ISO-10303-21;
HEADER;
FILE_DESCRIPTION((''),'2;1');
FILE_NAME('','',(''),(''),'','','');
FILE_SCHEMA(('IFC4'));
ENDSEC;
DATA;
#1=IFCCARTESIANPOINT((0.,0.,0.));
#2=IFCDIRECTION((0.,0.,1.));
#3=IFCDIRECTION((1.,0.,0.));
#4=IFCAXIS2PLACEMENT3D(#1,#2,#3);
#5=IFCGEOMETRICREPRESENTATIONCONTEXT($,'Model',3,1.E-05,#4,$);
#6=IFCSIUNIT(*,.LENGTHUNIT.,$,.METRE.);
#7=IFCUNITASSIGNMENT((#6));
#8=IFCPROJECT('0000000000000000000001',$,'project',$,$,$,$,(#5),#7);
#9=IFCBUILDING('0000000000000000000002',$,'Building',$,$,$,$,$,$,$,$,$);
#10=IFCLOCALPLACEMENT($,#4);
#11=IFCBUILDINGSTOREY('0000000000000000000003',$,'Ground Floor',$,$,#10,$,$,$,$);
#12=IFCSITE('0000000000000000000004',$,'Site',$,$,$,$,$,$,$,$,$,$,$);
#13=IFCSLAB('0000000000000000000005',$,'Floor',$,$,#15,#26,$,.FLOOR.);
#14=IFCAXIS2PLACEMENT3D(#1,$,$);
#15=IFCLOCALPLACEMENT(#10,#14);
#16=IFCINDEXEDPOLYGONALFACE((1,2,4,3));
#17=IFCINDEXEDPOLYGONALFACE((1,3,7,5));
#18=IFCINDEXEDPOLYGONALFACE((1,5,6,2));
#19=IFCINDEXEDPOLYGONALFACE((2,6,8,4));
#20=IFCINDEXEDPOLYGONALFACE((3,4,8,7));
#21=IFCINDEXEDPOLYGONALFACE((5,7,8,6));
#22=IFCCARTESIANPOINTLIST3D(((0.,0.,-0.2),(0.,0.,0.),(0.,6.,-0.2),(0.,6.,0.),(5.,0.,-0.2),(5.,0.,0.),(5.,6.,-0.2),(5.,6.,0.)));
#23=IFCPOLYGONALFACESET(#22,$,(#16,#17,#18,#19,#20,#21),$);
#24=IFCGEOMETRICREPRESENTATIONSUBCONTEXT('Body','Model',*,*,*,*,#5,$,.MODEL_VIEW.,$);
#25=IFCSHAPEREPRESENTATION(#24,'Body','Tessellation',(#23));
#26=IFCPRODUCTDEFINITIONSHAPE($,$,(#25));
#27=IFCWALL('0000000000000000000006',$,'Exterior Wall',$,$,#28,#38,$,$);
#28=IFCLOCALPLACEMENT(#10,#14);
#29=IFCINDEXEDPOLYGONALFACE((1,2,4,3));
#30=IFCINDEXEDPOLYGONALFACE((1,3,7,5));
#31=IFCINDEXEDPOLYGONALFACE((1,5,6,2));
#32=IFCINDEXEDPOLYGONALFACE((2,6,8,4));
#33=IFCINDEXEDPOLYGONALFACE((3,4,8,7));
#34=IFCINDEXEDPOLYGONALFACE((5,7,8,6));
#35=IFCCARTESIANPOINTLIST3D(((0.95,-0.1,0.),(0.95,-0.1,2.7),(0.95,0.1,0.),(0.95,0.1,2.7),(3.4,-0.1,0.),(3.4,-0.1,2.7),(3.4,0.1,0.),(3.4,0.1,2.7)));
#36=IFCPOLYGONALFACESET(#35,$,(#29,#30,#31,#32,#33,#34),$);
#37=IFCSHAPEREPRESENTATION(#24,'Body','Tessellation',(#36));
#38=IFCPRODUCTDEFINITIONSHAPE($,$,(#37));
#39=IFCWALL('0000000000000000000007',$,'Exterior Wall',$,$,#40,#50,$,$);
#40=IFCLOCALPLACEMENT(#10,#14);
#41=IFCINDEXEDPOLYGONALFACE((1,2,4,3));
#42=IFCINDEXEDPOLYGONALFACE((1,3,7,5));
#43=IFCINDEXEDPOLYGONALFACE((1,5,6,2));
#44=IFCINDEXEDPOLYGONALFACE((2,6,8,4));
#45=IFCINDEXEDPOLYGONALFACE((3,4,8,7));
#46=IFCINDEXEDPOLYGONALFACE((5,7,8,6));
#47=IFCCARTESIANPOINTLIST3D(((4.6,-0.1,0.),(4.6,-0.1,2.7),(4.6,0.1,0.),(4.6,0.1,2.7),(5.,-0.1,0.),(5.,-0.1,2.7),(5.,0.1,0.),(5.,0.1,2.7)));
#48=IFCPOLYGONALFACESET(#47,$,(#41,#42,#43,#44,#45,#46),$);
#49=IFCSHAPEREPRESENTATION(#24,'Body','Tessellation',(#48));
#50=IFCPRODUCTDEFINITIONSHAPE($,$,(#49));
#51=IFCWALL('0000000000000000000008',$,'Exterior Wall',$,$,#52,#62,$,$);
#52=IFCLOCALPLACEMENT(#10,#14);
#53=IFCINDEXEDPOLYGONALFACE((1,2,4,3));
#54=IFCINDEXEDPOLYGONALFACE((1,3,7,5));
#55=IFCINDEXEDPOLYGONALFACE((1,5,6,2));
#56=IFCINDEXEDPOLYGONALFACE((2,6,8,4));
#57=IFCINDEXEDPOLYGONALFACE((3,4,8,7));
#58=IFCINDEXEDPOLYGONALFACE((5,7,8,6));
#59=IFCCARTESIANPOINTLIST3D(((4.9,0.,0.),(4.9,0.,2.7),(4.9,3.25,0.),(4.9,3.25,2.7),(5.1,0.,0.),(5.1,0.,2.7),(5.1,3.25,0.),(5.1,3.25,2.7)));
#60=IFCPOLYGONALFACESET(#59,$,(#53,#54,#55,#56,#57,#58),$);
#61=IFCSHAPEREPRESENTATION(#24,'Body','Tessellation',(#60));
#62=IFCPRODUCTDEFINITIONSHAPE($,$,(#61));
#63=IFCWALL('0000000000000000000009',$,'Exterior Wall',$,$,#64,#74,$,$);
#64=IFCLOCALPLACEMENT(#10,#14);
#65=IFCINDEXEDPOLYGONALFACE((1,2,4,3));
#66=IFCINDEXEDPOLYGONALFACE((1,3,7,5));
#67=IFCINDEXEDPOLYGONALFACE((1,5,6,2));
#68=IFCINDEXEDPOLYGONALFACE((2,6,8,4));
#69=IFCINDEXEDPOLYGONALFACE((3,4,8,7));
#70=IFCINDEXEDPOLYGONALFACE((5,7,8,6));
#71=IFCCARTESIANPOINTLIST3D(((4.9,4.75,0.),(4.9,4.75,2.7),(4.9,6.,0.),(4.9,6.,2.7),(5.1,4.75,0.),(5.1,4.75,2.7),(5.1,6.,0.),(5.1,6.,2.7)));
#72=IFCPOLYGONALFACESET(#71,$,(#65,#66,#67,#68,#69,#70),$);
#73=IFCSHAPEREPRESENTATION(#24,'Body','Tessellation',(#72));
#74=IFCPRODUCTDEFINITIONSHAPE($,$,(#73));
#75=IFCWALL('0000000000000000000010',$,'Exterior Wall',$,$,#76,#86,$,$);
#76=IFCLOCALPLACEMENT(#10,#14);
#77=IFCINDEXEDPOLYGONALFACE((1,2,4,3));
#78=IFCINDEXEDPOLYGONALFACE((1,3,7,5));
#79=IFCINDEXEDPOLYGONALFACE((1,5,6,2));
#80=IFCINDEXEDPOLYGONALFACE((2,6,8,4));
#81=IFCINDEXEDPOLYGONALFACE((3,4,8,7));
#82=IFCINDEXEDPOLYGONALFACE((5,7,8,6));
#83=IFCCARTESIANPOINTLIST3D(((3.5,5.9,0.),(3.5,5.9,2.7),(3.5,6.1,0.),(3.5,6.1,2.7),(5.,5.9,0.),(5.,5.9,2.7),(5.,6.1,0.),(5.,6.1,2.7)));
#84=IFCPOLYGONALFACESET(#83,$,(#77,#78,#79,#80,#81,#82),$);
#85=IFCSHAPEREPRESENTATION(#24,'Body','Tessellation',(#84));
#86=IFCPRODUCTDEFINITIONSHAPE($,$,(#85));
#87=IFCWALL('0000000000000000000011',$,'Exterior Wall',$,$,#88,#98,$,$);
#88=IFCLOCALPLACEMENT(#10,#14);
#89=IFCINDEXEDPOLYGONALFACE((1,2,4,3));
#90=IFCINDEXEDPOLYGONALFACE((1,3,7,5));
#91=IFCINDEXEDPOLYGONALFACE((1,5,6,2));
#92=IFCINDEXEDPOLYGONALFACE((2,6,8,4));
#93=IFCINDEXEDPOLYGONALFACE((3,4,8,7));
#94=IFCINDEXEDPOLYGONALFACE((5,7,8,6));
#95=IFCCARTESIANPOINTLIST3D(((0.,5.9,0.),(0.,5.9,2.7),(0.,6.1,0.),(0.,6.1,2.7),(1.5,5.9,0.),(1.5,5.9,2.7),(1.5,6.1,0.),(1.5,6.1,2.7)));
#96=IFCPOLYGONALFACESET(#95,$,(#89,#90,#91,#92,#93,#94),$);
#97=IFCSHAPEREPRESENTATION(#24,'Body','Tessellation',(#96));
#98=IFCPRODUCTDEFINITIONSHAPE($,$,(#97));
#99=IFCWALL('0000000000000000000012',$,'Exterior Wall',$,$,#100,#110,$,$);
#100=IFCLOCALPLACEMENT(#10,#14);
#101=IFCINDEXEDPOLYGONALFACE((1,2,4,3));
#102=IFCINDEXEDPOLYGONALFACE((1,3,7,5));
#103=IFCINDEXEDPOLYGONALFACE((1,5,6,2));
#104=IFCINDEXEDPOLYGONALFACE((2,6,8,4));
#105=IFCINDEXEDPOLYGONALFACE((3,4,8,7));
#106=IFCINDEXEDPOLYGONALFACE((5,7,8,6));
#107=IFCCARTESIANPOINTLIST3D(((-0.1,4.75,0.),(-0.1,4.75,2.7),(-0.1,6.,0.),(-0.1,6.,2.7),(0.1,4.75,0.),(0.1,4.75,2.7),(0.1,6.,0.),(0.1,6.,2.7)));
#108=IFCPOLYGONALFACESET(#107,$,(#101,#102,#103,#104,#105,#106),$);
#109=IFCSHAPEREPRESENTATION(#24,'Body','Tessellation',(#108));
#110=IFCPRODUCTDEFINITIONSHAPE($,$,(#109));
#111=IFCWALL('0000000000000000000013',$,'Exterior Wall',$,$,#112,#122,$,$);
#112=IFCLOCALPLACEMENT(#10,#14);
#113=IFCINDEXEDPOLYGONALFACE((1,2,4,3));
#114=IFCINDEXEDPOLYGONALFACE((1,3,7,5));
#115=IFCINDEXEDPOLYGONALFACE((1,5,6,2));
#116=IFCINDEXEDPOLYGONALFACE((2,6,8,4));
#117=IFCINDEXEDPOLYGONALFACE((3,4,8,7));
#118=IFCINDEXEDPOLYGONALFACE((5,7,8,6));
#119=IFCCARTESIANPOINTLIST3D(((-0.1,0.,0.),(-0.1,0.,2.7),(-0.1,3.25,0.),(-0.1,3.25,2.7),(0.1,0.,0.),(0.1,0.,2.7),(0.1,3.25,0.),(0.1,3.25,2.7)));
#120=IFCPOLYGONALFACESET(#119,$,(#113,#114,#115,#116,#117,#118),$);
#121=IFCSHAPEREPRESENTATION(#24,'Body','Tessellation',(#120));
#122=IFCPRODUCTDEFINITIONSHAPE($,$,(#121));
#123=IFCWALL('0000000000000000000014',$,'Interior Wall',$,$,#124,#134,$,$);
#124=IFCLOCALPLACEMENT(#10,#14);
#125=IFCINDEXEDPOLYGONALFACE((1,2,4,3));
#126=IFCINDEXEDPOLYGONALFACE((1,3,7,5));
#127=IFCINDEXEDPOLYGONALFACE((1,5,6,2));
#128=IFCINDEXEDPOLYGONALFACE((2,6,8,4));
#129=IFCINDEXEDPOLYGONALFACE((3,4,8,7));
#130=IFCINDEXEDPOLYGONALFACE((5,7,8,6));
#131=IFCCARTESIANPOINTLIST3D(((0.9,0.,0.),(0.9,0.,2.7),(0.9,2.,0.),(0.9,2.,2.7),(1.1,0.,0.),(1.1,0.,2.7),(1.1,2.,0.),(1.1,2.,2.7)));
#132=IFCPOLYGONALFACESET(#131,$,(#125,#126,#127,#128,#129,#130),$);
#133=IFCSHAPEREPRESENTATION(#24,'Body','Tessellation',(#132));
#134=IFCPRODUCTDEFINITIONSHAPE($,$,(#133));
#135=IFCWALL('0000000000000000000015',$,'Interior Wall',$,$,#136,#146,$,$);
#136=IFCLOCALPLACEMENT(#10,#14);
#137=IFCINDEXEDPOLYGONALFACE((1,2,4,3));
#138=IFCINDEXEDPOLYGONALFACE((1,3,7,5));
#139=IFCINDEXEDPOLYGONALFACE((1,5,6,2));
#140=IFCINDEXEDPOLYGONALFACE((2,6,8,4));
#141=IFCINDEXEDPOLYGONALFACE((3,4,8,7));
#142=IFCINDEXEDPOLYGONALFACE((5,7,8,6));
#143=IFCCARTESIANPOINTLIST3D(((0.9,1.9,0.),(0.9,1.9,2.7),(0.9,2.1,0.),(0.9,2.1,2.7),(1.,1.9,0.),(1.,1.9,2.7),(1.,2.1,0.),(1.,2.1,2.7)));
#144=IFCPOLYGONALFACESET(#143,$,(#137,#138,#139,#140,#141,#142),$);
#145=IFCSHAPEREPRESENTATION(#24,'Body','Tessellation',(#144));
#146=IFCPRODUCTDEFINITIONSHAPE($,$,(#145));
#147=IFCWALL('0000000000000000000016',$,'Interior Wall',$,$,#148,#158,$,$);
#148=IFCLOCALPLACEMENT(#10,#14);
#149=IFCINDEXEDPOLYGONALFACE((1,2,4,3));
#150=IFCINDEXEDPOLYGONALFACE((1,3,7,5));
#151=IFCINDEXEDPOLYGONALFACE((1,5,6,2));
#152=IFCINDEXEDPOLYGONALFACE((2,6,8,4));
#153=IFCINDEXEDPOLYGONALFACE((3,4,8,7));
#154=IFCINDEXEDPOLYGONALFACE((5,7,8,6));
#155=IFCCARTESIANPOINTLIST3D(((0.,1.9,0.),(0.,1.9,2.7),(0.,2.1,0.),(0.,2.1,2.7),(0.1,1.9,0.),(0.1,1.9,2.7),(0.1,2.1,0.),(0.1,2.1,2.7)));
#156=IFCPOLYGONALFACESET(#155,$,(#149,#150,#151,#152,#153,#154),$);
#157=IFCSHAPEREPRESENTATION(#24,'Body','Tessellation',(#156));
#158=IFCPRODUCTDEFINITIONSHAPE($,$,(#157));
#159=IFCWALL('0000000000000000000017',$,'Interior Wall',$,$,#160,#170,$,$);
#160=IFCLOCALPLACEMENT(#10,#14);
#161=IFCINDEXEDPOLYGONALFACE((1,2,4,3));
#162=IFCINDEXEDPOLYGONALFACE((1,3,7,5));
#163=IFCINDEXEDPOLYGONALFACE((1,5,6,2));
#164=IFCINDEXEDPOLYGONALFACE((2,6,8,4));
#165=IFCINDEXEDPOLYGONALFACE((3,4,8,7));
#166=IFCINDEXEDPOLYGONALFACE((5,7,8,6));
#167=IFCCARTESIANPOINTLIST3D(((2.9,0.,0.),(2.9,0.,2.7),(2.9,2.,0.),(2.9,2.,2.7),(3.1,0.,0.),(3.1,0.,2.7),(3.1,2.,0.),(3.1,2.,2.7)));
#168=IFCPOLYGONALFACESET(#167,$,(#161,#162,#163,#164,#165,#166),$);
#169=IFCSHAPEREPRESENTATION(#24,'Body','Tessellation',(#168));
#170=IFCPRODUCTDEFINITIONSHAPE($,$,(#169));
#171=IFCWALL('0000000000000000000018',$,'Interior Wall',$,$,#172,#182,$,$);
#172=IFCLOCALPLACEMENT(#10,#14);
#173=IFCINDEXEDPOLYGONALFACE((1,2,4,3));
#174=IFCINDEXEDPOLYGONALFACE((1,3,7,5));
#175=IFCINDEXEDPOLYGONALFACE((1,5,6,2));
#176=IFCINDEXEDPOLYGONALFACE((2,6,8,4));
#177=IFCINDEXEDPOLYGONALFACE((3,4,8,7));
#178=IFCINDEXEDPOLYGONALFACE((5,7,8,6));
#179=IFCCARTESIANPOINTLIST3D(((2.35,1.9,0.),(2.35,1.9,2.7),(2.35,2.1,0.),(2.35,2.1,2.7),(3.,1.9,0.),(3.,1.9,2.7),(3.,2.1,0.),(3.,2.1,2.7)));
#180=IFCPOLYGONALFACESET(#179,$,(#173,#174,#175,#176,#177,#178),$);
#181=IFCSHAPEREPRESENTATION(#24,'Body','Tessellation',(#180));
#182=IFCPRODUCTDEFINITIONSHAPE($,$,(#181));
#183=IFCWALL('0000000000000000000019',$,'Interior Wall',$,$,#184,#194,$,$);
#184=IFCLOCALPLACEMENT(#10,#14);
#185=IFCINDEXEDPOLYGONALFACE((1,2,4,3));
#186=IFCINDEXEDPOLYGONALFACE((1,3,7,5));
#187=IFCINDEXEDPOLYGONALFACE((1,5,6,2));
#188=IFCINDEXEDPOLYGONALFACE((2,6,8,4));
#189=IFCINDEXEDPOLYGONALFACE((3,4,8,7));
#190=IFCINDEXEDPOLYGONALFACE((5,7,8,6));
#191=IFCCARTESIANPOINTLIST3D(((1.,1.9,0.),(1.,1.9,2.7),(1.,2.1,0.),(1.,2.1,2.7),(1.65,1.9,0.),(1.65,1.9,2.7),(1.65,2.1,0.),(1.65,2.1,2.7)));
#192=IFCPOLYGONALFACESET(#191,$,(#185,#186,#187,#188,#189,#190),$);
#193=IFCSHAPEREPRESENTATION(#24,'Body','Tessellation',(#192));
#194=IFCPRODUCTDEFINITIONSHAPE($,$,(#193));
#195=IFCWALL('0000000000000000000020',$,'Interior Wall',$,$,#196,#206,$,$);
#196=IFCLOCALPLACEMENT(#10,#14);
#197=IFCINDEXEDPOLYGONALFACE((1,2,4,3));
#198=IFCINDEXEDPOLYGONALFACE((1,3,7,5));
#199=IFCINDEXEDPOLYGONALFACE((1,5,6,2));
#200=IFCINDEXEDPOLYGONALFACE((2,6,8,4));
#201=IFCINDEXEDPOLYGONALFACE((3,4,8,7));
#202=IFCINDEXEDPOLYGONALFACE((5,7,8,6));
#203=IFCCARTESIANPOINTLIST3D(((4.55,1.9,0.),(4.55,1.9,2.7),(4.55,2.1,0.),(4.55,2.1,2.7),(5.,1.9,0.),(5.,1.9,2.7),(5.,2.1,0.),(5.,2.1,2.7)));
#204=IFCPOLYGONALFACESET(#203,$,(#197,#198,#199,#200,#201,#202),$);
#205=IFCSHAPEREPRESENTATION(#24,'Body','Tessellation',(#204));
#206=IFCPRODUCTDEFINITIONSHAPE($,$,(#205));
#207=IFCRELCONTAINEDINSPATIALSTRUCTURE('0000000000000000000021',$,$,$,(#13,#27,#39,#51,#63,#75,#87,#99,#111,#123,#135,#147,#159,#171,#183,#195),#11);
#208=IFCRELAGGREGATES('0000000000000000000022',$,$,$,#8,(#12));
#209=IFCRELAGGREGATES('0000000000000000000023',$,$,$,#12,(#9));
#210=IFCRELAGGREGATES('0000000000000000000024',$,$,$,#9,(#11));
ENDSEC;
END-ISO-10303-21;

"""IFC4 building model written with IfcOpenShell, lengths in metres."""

from ifc_helpers import new_model, si_unit, frame, origin_with_axes, place, context, subcontext, project, spatial, indexed_curve, outline, extrude, element, save


model = new_model("IFC4")

# Units and contexts
model_context = context("Model", 3, precision=1e-05, world=origin_with_axes())
body_context = subcontext(model_context, "Body", "Model", "MODEL_VIEW")
ifc_project = project(units=[si_unit("LENGTHUNIT", "METRE")], contexts=[model_context])

# Site, building, storey
site = spatial("IfcSite", under=ifc_project, Name="Site")
building = spatial("IfcBuilding", under=site, Name="Building")
storey_placement = place(None, origin_with_axes())
storey = spatial("IfcBuildingStorey", under=building, at=storey_placement, Name="Ground Floor")

# Slab
slab_placement = place(storey_placement, frame((0.0, 0.0, -0.2), z_axis=(0.0, 0.0, 1.0), x_axis=(1.0, 0.0, 0.0)))
element("IfcSlab", 1, at=slab_placement, inside=storey, Name="Floor", PredefinedType="FLOOR", context=body_context, shape_type="SweptSolid", body=[
    extrude(outline(indexed_curve([(0.0, 0.0), (5.0, 0.0), (5.0, 6.0), (0.0, 6.0)])), None, (0.0, 0.0, 1.0), 0.2),
])

# Walls
wall_1_placement = place(storey_placement, frame((0.95, 0.0, 0.0), z_axis=(0.0, 0.0, 1.0), x_axis=(1.0, 0.0, 0.0)))
element("IfcWall", 2, at=wall_1_placement, inside=storey, Name="Exterior Wall", context=body_context, shape_type="SweptSolid", body=[
    extrude(outline(indexed_curve([(0.0, 0.0), (0.0, 0.2), (2.45, 0.2), (2.45, 0.0), (0.0, 0.0)], self_intersect=False)), frame((0.0, -0.1, 0.0), z_axis=(0.0, 0.0, 1.0), x_axis=(1.0, 0.0, 0.0)), (0.0, 0.0, 1.0), 2.7),
])
wall_2_placement = place(storey_placement, frame((4.6, 0.0, 0.0), z_axis=(0.0, 0.0, 1.0), x_axis=(1.0, 0.0, 0.0)))
element("IfcWall", 3, at=wall_2_placement, inside=storey, Name="Exterior Wall", context=body_context, shape_type="SweptSolid", body=[
    extrude(outline(indexed_curve([(0.0, 0.0), (0.0, 0.2), (0.4, 0.2), (0.4, 0.0), (0.0, 0.0)], self_intersect=False)), frame((0.0, -0.1, 0.0), z_axis=(0.0, 0.0, 1.0), x_axis=(1.0, 0.0, 0.0)), (0.0, 0.0, 1.0), 2.7),
])
wall_3_placement = place(storey_placement, frame((5.0, 0.0, 0.0), z_axis=(0.0, 0.0, 1.0), x_axis=(0.0, 1.0, 0.0)))
element("IfcWall", 4, at=wall_3_placement, inside=storey, Name="Exterior Wall", context=body_context, shape_type="SweptSolid", body=[
    extrude(outline(indexed_curve([(0.0, 0.0), (0.0, 0.2), (3.25, 0.2), (3.25, 0.0), (0.0, 0.0)], self_intersect=False)), frame((0.0, -0.1, 0.0), z_axis=(0.0, 0.0, 1.0), x_axis=(1.0, 0.0, 0.0)), (0.0, 0.0, 1.0), 2.7),
])
wall_4_placement = place(storey_placement, frame((5.0, 4.75, 0.0), z_axis=(0.0, 0.0, 1.0), x_axis=(0.0, 1.0, 0.0)))
element("IfcWall", 5, at=wall_4_placement, inside=storey, Name="Exterior Wall", context=body_context, shape_type="SweptSolid", body=[
    extrude(outline(indexed_curve([(0.0, 0.0), (0.0, 0.2), (1.25, 0.2), (1.25, 0.0), (0.0, 0.0)], self_intersect=False)), frame((0.0, -0.1, 0.0), z_axis=(0.0, 0.0, 1.0), x_axis=(1.0, 0.0, 0.0)), (0.0, 0.0, 1.0), 2.7),
])
for number, where, z_axis, x_axis, name in (
    (6, (5.0, 6.0, 0.0), (0.0, 0.0, 1.0), (-1.0, 0.0, 0.0), "Exterior Wall"),
    (7, (1.5, 6.0, 0.0), (0.0, 0.0, 1.0), (-1.0, 0.0, 0.0), "Exterior Wall"),
):
    element("IfcWall", number, at=place(storey_placement, frame(where, z_axis=z_axis, x_axis=x_axis)), inside=storey, Name=name, context=body_context, shape_type="SweptSolid", body=[
        extrude(outline(indexed_curve([(0.0, 0.0), (0.0, 0.2), (1.5, 0.2), (1.5, 0.0), (0.0, 0.0)], self_intersect=False)), frame((0.0, -0.1, 0.0), z_axis=(0.0, 0.0, 1.0), x_axis=(1.0, 0.0, 0.0)), (0.0, 0.0, 1.0), 2.7),
    ])
wall_5_placement = place(storey_placement, frame((0.0, 6.0, 0.0), z_axis=(0.0, 0.0, 1.0), x_axis=(0.0, -1.0, 0.0)))
element("IfcWall", 8, at=wall_5_placement, inside=storey, Name="Exterior Wall", context=body_context, shape_type="SweptSolid", body=[
    extrude(outline(indexed_curve([(0.0, 0.0), (0.0, 0.2), (1.25, 0.2), (1.25, 0.0), (0.0, 0.0)], self_intersect=False)), frame((0.0, -0.1, 0.0), z_axis=(0.0, 0.0, 1.0), x_axis=(1.0, 0.0, 0.0)), (0.0, 0.0, 1.0), 2.7),
])
wall_6_placement = place(storey_placement, frame((0.0, 3.25, 0.0), z_axis=(0.0, 0.0, 1.0), x_axis=(0.0, -1.0, 0.0)))
element("IfcWall", 9, at=wall_6_placement, inside=storey, Name="Exterior Wall", context=body_context, shape_type="SweptSolid", body=[
    extrude(outline(indexed_curve([(0.0, 0.0), (0.0, 0.2), (3.25, 0.2), (3.25, 0.0), (0.0, 0.0)], self_intersect=False)), frame((0.0, -0.1, 0.0), z_axis=(0.0, 0.0, 1.0), x_axis=(1.0, 0.0, 0.0)), (0.0, 0.0, 1.0), 2.7),
])
wall_7_placement = place(storey_placement, frame((1.0, 0.0, 0.0), z_axis=(0.0, 0.0, 1.0), x_axis=(0.0, 1.0, 0.0)))
element("IfcWall", 10, at=wall_7_placement, inside=storey, Name="Interior Wall", context=body_context, shape_type="SweptSolid", body=[
    extrude(outline(indexed_curve([(0.0, 0.0), (0.0, 0.2), (2.0, 0.2), (2.0, 0.0), (0.0, 0.0)], self_intersect=False)), frame((0.0, -0.1, 0.0), z_axis=(0.0, 0.0, 1.0), x_axis=(1.0, 0.0, 0.0)), (0.0, 0.0, 1.0), 2.7),
])
for number, where, z_axis, x_axis, name in (
    (11, (1.0, 2.0, 0.0), (0.0, 0.0, 1.0), (-1.0, 0.0, 0.0), "Interior Wall"),
    (12, (0.1, 2.0, 0.0), (0.0, 0.0, 1.0), (-1.0, 0.0, 0.0), "Interior Wall"),
):
    element("IfcWall", number, at=place(storey_placement, frame(where, z_axis=z_axis, x_axis=x_axis)), inside=storey, Name=name, context=body_context, shape_type="SweptSolid", body=[
        extrude(outline(indexed_curve([(0.0, 0.0), (0.0, 0.2), (0.1, 0.2), (0.1, 0.0), (0.0, 0.0)], self_intersect=False)), frame((0.0, -0.1, 0.0), z_axis=(0.0, 0.0, 1.0), x_axis=(1.0, 0.0, 0.0)), (0.0, 0.0, 1.0), 2.7),
    ])
wall_8_placement = place(storey_placement, frame((3.0, 0.0, 0.0), z_axis=(0.0, 0.0, 1.0), x_axis=(0.0, 1.0, 0.0)))
element("IfcWall", 13, at=wall_8_placement, inside=storey, Name="Interior Wall", context=body_context, shape_type="SweptSolid", body=[
    extrude(outline(indexed_curve([(0.0, 0.0), (0.0, 0.2), (2.0, 0.2), (2.0, 0.0), (0.0, 0.0)], self_intersect=False)), frame((0.0, -0.1, 0.0), z_axis=(0.0, 0.0, 1.0), x_axis=(1.0, 0.0, 0.0)), (0.0, 0.0, 1.0), 2.7),
])
for number, where, z_axis, x_axis, name in (
    (14, (3.0, 2.0, 0.0), (0.0, 0.0, 1.0), (-1.0, 0.0, 0.0), "Interior Wall"),
    (15, (1.65, 2.0, 0.0), (0.0, 0.0, 1.0), (-1.0, 0.0, 0.0), "Interior Wall"),
):
    element("IfcWall", number, at=place(storey_placement, frame(where, z_axis=z_axis, x_axis=x_axis)), inside=storey, Name=name, context=body_context, shape_type="SweptSolid", body=[
        extrude(outline(indexed_curve([(0.0, 0.0), (0.0, 0.2), (0.65, 0.2), (0.65, 0.0), (0.0, 0.0)], self_intersect=False)), frame((0.0, -0.1, 0.0), z_axis=(0.0, 0.0, 1.0), x_axis=(1.0, 0.0, 0.0)), (0.0, 0.0, 1.0), 2.7),
    ])
for number, where, z_axis, x_axis, name in (
    (16, (5.0, 2.0, 0.0), (0.0, 0.0, 1.0), (-1.0, 0.0, 0.0), "Interior Wall"),
):
    element("IfcWall", number, at=place(storey_placement, frame(where, z_axis=z_axis, x_axis=x_axis)), inside=storey, Name=name, context=body_context, shape_type="SweptSolid", body=[
        extrude(outline(indexed_curve([(0.0, 0.0), (0.0, 0.2), (0.45, 0.2), (0.45, 0.0), (0.0, 0.0)], self_intersect=False)), frame((0.0, -0.1, 0.0), z_axis=(0.0, 0.0, 1.0), x_axis=(1.0, 0.0, 0.0)), (0.0, 0.0, 1.0), 2.7),
    ])

save(model, "model.ifc")
